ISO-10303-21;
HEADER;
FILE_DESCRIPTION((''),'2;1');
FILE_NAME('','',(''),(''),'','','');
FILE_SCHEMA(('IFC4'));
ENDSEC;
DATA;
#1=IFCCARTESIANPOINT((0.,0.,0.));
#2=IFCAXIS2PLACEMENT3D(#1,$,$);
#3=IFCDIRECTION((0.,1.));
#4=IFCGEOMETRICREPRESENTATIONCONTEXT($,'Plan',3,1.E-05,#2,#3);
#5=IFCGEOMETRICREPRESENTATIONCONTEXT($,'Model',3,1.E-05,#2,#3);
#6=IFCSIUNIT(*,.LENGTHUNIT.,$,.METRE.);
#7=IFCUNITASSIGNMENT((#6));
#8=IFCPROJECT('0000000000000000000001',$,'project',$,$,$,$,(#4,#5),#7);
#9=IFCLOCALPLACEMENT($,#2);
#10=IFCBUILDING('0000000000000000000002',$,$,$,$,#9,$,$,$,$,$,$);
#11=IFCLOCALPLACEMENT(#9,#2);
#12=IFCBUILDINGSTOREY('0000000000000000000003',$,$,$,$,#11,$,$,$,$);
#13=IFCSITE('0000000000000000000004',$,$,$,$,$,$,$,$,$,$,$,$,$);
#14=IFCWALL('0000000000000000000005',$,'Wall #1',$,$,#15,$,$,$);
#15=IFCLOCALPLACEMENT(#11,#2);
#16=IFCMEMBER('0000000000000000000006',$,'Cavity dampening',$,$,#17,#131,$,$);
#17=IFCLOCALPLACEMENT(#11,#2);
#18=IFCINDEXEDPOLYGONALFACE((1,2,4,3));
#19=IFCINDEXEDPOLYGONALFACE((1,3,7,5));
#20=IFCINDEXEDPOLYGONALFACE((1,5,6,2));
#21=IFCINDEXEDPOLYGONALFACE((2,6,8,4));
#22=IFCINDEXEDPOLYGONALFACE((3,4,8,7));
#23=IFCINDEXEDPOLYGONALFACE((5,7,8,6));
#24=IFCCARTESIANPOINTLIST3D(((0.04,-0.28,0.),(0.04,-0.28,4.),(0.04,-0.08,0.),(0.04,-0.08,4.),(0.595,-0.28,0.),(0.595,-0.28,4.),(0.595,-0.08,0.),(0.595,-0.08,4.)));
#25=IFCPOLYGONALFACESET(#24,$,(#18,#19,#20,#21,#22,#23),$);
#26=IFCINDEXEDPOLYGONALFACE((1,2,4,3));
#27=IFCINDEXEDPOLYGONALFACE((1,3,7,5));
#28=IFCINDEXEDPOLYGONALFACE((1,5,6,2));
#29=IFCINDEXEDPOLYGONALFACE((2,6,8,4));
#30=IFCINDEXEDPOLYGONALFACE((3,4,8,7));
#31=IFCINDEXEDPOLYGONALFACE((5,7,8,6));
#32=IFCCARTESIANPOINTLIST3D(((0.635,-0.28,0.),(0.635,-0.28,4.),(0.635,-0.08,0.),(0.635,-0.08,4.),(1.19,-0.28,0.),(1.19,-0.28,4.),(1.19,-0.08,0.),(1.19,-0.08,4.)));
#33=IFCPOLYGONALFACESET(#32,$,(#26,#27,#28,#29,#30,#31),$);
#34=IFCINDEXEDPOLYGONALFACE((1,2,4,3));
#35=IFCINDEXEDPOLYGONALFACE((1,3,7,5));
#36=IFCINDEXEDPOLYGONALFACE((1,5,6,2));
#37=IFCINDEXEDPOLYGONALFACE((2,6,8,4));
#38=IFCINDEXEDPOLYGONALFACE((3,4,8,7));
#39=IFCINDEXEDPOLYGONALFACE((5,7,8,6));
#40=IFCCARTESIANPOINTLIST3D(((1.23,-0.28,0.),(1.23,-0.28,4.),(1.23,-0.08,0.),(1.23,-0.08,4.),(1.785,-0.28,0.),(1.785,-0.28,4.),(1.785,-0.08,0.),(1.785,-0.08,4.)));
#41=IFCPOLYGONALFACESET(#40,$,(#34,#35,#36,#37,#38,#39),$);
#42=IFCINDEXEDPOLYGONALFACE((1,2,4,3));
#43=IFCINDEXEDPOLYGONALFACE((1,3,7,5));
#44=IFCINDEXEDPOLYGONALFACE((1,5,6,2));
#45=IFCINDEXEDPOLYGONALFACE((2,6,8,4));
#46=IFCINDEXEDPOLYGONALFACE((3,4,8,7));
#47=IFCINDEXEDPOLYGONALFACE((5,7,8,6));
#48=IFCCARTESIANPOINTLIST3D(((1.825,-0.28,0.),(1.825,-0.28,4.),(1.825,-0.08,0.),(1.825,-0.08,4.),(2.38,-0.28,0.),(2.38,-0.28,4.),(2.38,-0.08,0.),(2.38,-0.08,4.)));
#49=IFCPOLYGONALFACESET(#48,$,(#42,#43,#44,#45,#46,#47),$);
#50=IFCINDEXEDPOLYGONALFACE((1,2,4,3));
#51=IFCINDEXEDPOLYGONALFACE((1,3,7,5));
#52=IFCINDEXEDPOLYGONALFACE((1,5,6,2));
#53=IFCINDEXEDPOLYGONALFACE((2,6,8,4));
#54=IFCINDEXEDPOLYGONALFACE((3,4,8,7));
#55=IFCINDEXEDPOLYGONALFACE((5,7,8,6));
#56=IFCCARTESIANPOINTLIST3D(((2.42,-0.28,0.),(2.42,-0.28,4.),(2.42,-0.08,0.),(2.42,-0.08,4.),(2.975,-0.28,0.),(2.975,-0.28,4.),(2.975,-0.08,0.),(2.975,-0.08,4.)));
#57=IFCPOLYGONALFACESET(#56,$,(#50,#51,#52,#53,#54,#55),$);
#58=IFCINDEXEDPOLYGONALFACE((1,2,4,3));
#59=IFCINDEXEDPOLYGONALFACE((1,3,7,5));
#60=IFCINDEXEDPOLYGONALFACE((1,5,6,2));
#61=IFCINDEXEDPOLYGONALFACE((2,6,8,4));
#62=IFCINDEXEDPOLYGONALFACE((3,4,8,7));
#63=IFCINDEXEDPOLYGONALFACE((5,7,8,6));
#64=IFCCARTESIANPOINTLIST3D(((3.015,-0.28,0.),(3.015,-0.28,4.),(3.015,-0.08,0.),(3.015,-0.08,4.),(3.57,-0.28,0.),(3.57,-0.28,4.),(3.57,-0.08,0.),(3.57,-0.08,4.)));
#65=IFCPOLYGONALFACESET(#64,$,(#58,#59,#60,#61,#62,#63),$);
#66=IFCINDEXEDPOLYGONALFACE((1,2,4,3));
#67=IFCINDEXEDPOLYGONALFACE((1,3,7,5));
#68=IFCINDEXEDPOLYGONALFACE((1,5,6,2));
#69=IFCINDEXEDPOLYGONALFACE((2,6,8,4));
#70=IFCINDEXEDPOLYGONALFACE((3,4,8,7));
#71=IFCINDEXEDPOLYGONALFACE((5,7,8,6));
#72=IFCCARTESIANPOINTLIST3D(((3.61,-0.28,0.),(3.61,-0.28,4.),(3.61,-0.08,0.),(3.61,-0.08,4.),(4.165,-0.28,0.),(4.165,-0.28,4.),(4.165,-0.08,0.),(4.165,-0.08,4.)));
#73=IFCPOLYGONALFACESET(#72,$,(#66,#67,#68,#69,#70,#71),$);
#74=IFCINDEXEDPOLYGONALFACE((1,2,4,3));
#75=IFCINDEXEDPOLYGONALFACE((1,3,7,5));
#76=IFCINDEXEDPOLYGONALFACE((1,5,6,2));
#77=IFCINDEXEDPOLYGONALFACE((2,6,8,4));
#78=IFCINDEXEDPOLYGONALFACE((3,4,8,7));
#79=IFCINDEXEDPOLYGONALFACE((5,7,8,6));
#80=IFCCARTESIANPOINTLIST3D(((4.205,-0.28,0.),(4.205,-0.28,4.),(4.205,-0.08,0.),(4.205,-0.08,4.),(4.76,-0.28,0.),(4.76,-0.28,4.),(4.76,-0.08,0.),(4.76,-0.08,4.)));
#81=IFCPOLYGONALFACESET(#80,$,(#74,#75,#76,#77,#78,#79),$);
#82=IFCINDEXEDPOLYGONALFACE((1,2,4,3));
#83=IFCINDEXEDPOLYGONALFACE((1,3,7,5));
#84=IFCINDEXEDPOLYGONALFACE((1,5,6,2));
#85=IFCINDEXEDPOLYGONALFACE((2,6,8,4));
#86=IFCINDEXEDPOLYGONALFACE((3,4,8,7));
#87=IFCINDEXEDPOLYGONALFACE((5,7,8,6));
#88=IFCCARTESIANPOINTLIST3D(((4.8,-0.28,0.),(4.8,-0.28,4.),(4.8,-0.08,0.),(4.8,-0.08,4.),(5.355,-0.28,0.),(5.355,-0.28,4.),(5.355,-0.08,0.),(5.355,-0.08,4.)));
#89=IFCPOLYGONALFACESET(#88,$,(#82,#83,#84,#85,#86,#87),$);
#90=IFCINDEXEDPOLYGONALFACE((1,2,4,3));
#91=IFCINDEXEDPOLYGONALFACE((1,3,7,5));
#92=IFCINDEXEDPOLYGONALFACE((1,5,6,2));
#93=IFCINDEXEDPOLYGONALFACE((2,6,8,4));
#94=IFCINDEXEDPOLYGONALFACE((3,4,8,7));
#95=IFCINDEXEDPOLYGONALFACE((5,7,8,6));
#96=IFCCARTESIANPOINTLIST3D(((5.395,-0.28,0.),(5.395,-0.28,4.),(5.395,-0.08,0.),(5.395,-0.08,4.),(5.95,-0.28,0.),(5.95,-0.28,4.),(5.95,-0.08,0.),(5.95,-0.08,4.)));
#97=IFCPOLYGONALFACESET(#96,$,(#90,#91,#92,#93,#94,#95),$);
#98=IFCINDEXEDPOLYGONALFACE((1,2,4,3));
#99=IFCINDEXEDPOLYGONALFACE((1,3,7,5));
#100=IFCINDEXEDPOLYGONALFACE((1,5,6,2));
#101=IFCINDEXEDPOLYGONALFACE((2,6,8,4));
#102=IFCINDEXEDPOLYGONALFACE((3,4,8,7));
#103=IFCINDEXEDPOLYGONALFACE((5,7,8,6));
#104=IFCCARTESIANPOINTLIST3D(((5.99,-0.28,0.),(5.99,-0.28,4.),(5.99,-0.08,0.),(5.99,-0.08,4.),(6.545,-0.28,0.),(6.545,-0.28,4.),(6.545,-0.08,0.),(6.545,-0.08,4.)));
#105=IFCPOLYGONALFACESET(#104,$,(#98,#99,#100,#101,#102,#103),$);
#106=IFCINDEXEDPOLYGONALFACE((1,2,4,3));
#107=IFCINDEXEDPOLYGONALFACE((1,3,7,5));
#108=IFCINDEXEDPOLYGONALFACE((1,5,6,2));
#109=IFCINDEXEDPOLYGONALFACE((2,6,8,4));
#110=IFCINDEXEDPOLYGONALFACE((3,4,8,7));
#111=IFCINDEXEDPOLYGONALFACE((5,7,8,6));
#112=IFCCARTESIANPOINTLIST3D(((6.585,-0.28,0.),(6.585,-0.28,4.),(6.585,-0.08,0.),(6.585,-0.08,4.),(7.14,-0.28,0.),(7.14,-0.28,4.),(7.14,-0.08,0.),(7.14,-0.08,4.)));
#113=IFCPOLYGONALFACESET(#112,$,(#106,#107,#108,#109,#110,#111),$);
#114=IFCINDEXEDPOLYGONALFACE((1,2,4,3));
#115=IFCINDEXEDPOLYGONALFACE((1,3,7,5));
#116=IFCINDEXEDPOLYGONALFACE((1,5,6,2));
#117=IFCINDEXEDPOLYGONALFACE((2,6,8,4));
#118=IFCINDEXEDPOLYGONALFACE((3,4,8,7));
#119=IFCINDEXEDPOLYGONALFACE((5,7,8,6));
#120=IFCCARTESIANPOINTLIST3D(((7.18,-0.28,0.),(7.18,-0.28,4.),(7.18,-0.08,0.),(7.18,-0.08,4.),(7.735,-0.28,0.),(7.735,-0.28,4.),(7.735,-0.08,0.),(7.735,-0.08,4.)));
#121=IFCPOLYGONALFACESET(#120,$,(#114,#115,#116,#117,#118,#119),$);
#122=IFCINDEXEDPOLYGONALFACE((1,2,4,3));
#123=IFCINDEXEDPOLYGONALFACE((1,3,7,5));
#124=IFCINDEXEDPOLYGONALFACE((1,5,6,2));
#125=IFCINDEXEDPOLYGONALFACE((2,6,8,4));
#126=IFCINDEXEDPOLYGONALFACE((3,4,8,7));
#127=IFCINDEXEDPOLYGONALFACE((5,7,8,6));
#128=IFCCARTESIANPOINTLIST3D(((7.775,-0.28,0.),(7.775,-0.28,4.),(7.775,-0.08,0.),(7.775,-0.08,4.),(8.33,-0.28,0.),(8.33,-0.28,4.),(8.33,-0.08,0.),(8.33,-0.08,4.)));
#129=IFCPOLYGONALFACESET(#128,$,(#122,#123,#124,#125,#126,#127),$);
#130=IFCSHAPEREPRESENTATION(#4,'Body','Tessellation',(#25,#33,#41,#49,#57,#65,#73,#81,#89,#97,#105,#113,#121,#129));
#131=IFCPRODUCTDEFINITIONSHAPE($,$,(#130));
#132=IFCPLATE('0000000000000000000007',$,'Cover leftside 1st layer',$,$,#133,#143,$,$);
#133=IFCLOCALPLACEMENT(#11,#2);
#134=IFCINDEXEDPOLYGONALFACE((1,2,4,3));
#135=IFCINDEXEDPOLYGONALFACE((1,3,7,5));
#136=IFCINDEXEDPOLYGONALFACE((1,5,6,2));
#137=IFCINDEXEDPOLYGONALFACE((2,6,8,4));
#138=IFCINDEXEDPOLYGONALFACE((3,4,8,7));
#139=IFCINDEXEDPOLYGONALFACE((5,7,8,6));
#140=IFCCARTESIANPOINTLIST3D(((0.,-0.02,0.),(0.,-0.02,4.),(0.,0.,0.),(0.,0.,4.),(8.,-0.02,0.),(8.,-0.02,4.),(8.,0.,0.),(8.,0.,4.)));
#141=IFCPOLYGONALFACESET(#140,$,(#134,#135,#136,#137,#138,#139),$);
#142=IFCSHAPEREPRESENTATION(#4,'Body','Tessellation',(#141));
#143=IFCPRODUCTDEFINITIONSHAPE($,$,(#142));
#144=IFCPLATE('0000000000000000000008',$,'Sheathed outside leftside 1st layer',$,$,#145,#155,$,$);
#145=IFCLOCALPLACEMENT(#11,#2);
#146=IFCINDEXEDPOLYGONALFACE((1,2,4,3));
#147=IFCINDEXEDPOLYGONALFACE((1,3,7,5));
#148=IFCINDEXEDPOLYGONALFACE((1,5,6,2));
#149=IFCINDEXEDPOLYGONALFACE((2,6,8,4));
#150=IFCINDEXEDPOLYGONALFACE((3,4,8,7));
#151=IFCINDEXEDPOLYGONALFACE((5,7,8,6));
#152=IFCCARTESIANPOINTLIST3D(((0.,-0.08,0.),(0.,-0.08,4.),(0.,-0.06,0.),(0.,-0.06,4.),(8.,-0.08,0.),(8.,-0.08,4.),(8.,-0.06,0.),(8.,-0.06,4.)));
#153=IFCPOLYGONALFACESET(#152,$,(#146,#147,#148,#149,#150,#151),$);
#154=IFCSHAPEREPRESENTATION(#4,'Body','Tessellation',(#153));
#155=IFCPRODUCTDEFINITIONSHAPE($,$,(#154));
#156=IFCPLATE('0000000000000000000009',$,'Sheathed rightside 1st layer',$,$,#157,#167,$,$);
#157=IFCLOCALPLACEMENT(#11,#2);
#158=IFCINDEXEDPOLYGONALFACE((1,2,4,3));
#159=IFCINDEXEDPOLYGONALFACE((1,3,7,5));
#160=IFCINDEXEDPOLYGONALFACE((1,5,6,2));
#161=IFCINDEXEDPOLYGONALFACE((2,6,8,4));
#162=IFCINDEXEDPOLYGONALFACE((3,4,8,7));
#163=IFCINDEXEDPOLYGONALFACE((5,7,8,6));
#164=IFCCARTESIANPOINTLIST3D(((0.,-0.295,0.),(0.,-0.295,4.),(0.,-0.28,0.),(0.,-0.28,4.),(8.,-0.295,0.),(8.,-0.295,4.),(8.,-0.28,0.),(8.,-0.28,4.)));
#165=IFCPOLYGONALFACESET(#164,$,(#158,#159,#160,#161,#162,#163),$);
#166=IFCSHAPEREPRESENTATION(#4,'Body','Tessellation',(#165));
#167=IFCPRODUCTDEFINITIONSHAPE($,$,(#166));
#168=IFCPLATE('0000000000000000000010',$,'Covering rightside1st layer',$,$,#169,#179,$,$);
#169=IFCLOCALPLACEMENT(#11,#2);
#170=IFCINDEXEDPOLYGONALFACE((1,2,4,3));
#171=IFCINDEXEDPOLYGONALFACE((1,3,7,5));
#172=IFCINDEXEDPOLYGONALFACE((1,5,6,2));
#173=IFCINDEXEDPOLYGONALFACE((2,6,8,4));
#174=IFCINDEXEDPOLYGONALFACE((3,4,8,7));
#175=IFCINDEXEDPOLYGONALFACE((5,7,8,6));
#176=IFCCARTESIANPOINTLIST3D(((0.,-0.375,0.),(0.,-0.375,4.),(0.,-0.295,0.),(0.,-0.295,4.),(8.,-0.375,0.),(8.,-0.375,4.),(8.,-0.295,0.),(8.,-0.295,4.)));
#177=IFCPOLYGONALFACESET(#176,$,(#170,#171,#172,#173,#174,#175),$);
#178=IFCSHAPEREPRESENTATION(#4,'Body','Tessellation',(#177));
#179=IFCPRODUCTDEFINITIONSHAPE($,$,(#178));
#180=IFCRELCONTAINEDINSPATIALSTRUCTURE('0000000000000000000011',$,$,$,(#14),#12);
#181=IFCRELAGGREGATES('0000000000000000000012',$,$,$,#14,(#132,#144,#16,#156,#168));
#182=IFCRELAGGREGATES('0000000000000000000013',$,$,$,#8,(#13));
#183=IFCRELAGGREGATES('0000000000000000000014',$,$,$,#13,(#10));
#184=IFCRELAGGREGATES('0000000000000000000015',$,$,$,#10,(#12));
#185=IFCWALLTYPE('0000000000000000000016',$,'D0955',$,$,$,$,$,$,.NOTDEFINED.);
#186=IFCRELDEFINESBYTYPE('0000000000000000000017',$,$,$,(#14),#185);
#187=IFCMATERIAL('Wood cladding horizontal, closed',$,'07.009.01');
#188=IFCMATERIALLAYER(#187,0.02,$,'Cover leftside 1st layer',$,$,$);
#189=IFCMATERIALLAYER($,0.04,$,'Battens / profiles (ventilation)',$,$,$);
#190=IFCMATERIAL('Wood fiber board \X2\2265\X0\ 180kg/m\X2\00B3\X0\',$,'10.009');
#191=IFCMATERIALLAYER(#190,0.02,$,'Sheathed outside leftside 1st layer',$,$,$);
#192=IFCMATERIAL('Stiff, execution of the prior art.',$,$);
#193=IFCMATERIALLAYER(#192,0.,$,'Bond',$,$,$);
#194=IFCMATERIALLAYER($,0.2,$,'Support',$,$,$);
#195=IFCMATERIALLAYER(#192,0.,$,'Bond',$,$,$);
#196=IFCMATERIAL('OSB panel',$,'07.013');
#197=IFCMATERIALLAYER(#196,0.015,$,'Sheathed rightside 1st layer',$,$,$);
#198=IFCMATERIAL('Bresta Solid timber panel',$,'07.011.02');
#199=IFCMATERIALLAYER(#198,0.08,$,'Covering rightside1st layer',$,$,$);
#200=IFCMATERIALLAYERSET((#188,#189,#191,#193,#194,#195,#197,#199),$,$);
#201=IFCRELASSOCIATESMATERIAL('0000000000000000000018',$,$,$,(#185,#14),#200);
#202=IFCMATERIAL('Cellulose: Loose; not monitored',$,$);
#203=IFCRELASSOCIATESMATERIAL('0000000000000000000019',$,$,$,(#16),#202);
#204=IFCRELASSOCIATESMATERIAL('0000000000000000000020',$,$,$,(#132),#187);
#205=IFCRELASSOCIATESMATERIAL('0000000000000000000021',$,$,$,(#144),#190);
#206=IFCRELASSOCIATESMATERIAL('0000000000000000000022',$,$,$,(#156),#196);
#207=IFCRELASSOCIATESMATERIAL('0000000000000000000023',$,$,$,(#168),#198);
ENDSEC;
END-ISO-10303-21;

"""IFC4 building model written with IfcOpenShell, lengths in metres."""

from ifc_helpers import new_model, si_unit, direction, frame, frame_2d, origin, origin_with_axes, place, context, project, spatial, rectangle, extrude, material, layer, layer_set, type_object, element, aggregate, save


model = new_model("IFC4")

# Units and contexts
plan_context = context("Plan", 3, precision=1e-05, world=origin(), true_north=direction((0.0, 1.0)))
model_context = context("Model", 3, precision=1e-05, world=origin(), true_north=direction((0.0, 1.0)))
ifc_project = project(units=[si_unit("LENGTHUNIT", "METRE")], contexts=[plan_context, model_context])

# Site, building, storey
site = spatial("IfcSite", under=ifc_project)
building_placement = place(None, origin())
building = spatial("IfcBuilding", under=site, at=building_placement)
storey_placement = place(building_placement, origin())
storey = spatial("IfcBuildingStorey", under=building, at=storey_placement)

# Wall, member, plates
ifc_material_1 = material(Name="Wood cladding horizontal, closed", Category="07.009.01")
ifc_layer_1 = layer(ifc_material_1, 0.02, Name="Cover leftside 1st layer")
ifc_layer_2 = layer(None, 0.04, Name="Battens / profiles (ventilation)")
ifc_material_2 = material(Name="Wood fiber board ≥ 180kg/m³", Category="10.009")
ifc_layer_3 = layer(ifc_material_2, 0.02, Name="Sheathed outside leftside 1st layer")
ifc_material_3 = material(Name="Stiff, execution of the prior art.")
ifc_layer_4 = layer(ifc_material_3, 0.0, Name="Bond")
ifc_layer_5 = layer(None, 0.2, Name="Support")
ifc_layer_6 = layer(ifc_material_3, 0.0, Name="Bond")
ifc_material_4 = material(Name="OSB panel", Category="07.013")
ifc_layer_7 = layer(ifc_material_4, 0.015, Name="Sheathed rightside 1st layer")
ifc_material_5 = material(Name="Bresta Solid timber panel", Category="07.011.02")
ifc_layer_8 = layer(ifc_material_5, 0.08, Name="Covering rightside1st layer")
ifc_layer_set = layer_set([ifc_layer_1, ifc_layer_2, ifc_layer_3, ifc_layer_4, ifc_layer_5, ifc_layer_6, ifc_layer_7, ifc_layer_8])
wall_type = type_object("IfcWallType", Name="D0955", PredefinedType="NOTDEFINED", material=ifc_layer_set)
wall_placement = place(None, frame((0.0, 0.0, 0.0), z_axis=(0.0, -1.0, 0.0), x_axis=(1.0, 0.0, 0.0)))
wall = element("IfcWall", 1, at=wall_placement, inside=storey, type_object=wall_type, material=ifc_layer_set, Name="Wall #1")
ifc_material_6 = material(Name="Cellulose: Loose; not monitored")
member_1_placement = place(wall_placement, origin())
member_1 = element("IfcMember", 2, at=member_1_placement, material=ifc_material_6, Name="Cavity dampening", context=plan_context, shape_type="SweptSolid", body=[
    extrude(rectangle(XDim=0.555, YDim=0.2, at=frame_2d((0.2775, 0.1), x_axis=(1.0, 0.0))), frame((0.04, 4.0, 0.08), z_axis=(0.0, -1.0, 0.0), x_axis=(1.0, 0.0, 0.0)), (0.0, 0.0, 1.0), 4.0),
    extrude(rectangle(XDim=0.555, YDim=0.2, at=frame_2d((0.2775, 0.1), x_axis=(1.0, 0.0))), frame((0.635, 4.0, 0.08), z_axis=(0.0, -1.0, 0.0), x_axis=(1.0, 0.0, 0.0)), (0.0, 0.0, 1.0), 4.0),
    extrude(rectangle(XDim=0.555, YDim=0.2, at=frame_2d((0.2775, 0.1), x_axis=(1.0, 0.0))), frame((1.23, 4.0, 0.08), z_axis=(0.0, -1.0, 0.0), x_axis=(1.0, 0.0, 0.0)), (0.0, 0.0, 1.0), 4.0),
    extrude(rectangle(XDim=0.555, YDim=0.2, at=frame_2d((0.2775, 0.1), x_axis=(1.0, 0.0))), frame((1.825, 4.0, 0.08), z_axis=(0.0, -1.0, 0.0), x_axis=(1.0, 0.0, 0.0)), (0.0, 0.0, 1.0), 4.0),
    extrude(rectangle(XDim=0.555, YDim=0.2, at=frame_2d((0.2775, 0.1), x_axis=(1.0, 0.0))), frame((2.42, 4.0, 0.08), z_axis=(0.0, -1.0, 0.0), x_axis=(1.0, 0.0, 0.0)), (0.0, 0.0, 1.0), 4.0),
    extrude(rectangle(XDim=0.555, YDim=0.2, at=frame_2d((0.2775, 0.1), x_axis=(1.0, 0.0))), frame((3.015, 4.0, 0.08), z_axis=(0.0, -1.0, 0.0), x_axis=(1.0, 0.0, 0.0)), (0.0, 0.0, 1.0), 4.0),
    extrude(rectangle(XDim=0.555, YDim=0.2, at=frame_2d((0.2775, 0.1), x_axis=(1.0, 0.0))), frame((3.61, 4.0, 0.08), z_axis=(0.0, -1.0, 0.0), x_axis=(1.0, 0.0, 0.0)), (0.0, 0.0, 1.0), 4.0),
    extrude(rectangle(XDim=0.555, YDim=0.2, at=frame_2d((0.2775, 0.1), x_axis=(1.0, 0.0))), frame((4.205, 4.0, 0.08), z_axis=(0.0, -1.0, 0.0), x_axis=(1.0, 0.0, 0.0)), (0.0, 0.0, 1.0), 4.0),
    extrude(rectangle(XDim=0.555, YDim=0.2, at=frame_2d((0.2775, 0.1), x_axis=(1.0, 0.0))), frame((4.8, 4.0, 0.08), z_axis=(0.0, -1.0, 0.0), x_axis=(1.0, 0.0, 0.0)), (0.0, 0.0, 1.0), 4.0),
    extrude(rectangle(XDim=0.555, YDim=0.2, at=frame_2d((0.2775, 0.1), x_axis=(1.0, 0.0))), frame((5.395, 4.0, 0.08), z_axis=(0.0, -1.0, 0.0), x_axis=(1.0, 0.0, 0.0)), (0.0, 0.0, 1.0), 4.0),
    extrude(rectangle(XDim=0.555, YDim=0.2, at=frame_2d((0.2775, 0.1), x_axis=(1.0, 0.0))), frame((5.99, 4.0, 0.08), z_axis=(0.0, -1.0, 0.0), x_axis=(1.0, 0.0, 0.0)), (0.0, 0.0, 1.0), 4.0),
    extrude(rectangle(XDim=0.555, YDim=0.2, at=frame_2d((0.2775, 0.1), x_axis=(1.0, 0.0))), frame((6.585, 4.0, 0.08), z_axis=(0.0, -1.0, 0.0), x_axis=(1.0, 0.0, 0.0)), (0.0, 0.0, 1.0), 4.0),
    extrude(rectangle(XDim=0.555, YDim=0.2, at=frame_2d((0.2775, 0.1), x_axis=(1.0, 0.0))), frame((7.18, 4.0, 0.08), z_axis=(0.0, -1.0, 0.0), x_axis=(1.0, 0.0, 0.0)), (0.0, 0.0, 1.0), 4.0),
    extrude(rectangle(XDim=0.555, YDim=0.2, at=frame_2d((0.2775, 0.1), x_axis=(1.0, 0.0))), frame((7.775, 4.0, 0.08), z_axis=(0.0, -1.0, 0.0), x_axis=(1.0, 0.0, 0.0)), (0.0, 0.0, 1.0), 4.0),
])
plate_1_placement = place(wall_placement, origin())
plate_1 = element("IfcPlate", 3, at=plate_1_placement, material=ifc_material_1, Name="Cover leftside 1st layer", context=plan_context, shape_type="SweptSolid", body=[
    extrude(rectangle(XDim=8.0, YDim=4.0, at=frame_2d((4.0, 2.0), x_axis=(1.0, 0.0))), origin_with_axes(), (0.0, 0.0, 1.0), 0.02),
])
plate_2_placement = place(wall_placement, origin())
plate_2 = element("IfcPlate", 4, at=plate_2_placement, material=ifc_material_2, Name="Sheathed outside leftside 1st layer", context=plan_context, shape_type="SweptSolid", body=[
    extrude(rectangle(XDim=8.0, YDim=4.0, at=frame_2d((4.0, 2.0), x_axis=(1.0, 0.0))), frame((0.0, 0.0, 0.06), z_axis=(0.0, 0.0, 1.0), x_axis=(1.0, 0.0, 0.0)), (0.0, 0.0, 1.0), 0.02),
])
plate_3_placement = place(wall_placement, origin())
plate_3 = element("IfcPlate", 5, at=plate_3_placement, material=ifc_material_4, Name="Sheathed rightside 1st layer", context=plan_context, shape_type="SweptSolid", body=[
    extrude(rectangle(XDim=8.0, YDim=4.0, at=frame_2d((4.0, 2.0), x_axis=(1.0, 0.0))), frame((0.0, 0.0, 0.28), z_axis=(0.0, 0.0, 1.0), x_axis=(1.0, 0.0, 0.0)), (0.0, 0.0, 1.0), 0.015),
])
plate_4_placement = place(wall_placement, origin())
plate_4 = element("IfcPlate", 6, at=plate_4_placement, material=ifc_material_5, Name="Covering rightside1st layer", context=plan_context, shape_type="SweptSolid", body=[
    extrude(rectangle(XDim=8.0, YDim=4.0, at=frame_2d((4.0, 2.0), x_axis=(1.0, 0.0))), frame((0.0, 0.0, 0.295), z_axis=(0.0, 0.0, 1.0), x_axis=(1.0, 0.0, 0.0)), (0.0, 0.0, 1.0), 0.08),
])
aggregate(wall, [plate_1, plate_2, member_1, plate_3, plate_4])

save(model, "model.ifc")
